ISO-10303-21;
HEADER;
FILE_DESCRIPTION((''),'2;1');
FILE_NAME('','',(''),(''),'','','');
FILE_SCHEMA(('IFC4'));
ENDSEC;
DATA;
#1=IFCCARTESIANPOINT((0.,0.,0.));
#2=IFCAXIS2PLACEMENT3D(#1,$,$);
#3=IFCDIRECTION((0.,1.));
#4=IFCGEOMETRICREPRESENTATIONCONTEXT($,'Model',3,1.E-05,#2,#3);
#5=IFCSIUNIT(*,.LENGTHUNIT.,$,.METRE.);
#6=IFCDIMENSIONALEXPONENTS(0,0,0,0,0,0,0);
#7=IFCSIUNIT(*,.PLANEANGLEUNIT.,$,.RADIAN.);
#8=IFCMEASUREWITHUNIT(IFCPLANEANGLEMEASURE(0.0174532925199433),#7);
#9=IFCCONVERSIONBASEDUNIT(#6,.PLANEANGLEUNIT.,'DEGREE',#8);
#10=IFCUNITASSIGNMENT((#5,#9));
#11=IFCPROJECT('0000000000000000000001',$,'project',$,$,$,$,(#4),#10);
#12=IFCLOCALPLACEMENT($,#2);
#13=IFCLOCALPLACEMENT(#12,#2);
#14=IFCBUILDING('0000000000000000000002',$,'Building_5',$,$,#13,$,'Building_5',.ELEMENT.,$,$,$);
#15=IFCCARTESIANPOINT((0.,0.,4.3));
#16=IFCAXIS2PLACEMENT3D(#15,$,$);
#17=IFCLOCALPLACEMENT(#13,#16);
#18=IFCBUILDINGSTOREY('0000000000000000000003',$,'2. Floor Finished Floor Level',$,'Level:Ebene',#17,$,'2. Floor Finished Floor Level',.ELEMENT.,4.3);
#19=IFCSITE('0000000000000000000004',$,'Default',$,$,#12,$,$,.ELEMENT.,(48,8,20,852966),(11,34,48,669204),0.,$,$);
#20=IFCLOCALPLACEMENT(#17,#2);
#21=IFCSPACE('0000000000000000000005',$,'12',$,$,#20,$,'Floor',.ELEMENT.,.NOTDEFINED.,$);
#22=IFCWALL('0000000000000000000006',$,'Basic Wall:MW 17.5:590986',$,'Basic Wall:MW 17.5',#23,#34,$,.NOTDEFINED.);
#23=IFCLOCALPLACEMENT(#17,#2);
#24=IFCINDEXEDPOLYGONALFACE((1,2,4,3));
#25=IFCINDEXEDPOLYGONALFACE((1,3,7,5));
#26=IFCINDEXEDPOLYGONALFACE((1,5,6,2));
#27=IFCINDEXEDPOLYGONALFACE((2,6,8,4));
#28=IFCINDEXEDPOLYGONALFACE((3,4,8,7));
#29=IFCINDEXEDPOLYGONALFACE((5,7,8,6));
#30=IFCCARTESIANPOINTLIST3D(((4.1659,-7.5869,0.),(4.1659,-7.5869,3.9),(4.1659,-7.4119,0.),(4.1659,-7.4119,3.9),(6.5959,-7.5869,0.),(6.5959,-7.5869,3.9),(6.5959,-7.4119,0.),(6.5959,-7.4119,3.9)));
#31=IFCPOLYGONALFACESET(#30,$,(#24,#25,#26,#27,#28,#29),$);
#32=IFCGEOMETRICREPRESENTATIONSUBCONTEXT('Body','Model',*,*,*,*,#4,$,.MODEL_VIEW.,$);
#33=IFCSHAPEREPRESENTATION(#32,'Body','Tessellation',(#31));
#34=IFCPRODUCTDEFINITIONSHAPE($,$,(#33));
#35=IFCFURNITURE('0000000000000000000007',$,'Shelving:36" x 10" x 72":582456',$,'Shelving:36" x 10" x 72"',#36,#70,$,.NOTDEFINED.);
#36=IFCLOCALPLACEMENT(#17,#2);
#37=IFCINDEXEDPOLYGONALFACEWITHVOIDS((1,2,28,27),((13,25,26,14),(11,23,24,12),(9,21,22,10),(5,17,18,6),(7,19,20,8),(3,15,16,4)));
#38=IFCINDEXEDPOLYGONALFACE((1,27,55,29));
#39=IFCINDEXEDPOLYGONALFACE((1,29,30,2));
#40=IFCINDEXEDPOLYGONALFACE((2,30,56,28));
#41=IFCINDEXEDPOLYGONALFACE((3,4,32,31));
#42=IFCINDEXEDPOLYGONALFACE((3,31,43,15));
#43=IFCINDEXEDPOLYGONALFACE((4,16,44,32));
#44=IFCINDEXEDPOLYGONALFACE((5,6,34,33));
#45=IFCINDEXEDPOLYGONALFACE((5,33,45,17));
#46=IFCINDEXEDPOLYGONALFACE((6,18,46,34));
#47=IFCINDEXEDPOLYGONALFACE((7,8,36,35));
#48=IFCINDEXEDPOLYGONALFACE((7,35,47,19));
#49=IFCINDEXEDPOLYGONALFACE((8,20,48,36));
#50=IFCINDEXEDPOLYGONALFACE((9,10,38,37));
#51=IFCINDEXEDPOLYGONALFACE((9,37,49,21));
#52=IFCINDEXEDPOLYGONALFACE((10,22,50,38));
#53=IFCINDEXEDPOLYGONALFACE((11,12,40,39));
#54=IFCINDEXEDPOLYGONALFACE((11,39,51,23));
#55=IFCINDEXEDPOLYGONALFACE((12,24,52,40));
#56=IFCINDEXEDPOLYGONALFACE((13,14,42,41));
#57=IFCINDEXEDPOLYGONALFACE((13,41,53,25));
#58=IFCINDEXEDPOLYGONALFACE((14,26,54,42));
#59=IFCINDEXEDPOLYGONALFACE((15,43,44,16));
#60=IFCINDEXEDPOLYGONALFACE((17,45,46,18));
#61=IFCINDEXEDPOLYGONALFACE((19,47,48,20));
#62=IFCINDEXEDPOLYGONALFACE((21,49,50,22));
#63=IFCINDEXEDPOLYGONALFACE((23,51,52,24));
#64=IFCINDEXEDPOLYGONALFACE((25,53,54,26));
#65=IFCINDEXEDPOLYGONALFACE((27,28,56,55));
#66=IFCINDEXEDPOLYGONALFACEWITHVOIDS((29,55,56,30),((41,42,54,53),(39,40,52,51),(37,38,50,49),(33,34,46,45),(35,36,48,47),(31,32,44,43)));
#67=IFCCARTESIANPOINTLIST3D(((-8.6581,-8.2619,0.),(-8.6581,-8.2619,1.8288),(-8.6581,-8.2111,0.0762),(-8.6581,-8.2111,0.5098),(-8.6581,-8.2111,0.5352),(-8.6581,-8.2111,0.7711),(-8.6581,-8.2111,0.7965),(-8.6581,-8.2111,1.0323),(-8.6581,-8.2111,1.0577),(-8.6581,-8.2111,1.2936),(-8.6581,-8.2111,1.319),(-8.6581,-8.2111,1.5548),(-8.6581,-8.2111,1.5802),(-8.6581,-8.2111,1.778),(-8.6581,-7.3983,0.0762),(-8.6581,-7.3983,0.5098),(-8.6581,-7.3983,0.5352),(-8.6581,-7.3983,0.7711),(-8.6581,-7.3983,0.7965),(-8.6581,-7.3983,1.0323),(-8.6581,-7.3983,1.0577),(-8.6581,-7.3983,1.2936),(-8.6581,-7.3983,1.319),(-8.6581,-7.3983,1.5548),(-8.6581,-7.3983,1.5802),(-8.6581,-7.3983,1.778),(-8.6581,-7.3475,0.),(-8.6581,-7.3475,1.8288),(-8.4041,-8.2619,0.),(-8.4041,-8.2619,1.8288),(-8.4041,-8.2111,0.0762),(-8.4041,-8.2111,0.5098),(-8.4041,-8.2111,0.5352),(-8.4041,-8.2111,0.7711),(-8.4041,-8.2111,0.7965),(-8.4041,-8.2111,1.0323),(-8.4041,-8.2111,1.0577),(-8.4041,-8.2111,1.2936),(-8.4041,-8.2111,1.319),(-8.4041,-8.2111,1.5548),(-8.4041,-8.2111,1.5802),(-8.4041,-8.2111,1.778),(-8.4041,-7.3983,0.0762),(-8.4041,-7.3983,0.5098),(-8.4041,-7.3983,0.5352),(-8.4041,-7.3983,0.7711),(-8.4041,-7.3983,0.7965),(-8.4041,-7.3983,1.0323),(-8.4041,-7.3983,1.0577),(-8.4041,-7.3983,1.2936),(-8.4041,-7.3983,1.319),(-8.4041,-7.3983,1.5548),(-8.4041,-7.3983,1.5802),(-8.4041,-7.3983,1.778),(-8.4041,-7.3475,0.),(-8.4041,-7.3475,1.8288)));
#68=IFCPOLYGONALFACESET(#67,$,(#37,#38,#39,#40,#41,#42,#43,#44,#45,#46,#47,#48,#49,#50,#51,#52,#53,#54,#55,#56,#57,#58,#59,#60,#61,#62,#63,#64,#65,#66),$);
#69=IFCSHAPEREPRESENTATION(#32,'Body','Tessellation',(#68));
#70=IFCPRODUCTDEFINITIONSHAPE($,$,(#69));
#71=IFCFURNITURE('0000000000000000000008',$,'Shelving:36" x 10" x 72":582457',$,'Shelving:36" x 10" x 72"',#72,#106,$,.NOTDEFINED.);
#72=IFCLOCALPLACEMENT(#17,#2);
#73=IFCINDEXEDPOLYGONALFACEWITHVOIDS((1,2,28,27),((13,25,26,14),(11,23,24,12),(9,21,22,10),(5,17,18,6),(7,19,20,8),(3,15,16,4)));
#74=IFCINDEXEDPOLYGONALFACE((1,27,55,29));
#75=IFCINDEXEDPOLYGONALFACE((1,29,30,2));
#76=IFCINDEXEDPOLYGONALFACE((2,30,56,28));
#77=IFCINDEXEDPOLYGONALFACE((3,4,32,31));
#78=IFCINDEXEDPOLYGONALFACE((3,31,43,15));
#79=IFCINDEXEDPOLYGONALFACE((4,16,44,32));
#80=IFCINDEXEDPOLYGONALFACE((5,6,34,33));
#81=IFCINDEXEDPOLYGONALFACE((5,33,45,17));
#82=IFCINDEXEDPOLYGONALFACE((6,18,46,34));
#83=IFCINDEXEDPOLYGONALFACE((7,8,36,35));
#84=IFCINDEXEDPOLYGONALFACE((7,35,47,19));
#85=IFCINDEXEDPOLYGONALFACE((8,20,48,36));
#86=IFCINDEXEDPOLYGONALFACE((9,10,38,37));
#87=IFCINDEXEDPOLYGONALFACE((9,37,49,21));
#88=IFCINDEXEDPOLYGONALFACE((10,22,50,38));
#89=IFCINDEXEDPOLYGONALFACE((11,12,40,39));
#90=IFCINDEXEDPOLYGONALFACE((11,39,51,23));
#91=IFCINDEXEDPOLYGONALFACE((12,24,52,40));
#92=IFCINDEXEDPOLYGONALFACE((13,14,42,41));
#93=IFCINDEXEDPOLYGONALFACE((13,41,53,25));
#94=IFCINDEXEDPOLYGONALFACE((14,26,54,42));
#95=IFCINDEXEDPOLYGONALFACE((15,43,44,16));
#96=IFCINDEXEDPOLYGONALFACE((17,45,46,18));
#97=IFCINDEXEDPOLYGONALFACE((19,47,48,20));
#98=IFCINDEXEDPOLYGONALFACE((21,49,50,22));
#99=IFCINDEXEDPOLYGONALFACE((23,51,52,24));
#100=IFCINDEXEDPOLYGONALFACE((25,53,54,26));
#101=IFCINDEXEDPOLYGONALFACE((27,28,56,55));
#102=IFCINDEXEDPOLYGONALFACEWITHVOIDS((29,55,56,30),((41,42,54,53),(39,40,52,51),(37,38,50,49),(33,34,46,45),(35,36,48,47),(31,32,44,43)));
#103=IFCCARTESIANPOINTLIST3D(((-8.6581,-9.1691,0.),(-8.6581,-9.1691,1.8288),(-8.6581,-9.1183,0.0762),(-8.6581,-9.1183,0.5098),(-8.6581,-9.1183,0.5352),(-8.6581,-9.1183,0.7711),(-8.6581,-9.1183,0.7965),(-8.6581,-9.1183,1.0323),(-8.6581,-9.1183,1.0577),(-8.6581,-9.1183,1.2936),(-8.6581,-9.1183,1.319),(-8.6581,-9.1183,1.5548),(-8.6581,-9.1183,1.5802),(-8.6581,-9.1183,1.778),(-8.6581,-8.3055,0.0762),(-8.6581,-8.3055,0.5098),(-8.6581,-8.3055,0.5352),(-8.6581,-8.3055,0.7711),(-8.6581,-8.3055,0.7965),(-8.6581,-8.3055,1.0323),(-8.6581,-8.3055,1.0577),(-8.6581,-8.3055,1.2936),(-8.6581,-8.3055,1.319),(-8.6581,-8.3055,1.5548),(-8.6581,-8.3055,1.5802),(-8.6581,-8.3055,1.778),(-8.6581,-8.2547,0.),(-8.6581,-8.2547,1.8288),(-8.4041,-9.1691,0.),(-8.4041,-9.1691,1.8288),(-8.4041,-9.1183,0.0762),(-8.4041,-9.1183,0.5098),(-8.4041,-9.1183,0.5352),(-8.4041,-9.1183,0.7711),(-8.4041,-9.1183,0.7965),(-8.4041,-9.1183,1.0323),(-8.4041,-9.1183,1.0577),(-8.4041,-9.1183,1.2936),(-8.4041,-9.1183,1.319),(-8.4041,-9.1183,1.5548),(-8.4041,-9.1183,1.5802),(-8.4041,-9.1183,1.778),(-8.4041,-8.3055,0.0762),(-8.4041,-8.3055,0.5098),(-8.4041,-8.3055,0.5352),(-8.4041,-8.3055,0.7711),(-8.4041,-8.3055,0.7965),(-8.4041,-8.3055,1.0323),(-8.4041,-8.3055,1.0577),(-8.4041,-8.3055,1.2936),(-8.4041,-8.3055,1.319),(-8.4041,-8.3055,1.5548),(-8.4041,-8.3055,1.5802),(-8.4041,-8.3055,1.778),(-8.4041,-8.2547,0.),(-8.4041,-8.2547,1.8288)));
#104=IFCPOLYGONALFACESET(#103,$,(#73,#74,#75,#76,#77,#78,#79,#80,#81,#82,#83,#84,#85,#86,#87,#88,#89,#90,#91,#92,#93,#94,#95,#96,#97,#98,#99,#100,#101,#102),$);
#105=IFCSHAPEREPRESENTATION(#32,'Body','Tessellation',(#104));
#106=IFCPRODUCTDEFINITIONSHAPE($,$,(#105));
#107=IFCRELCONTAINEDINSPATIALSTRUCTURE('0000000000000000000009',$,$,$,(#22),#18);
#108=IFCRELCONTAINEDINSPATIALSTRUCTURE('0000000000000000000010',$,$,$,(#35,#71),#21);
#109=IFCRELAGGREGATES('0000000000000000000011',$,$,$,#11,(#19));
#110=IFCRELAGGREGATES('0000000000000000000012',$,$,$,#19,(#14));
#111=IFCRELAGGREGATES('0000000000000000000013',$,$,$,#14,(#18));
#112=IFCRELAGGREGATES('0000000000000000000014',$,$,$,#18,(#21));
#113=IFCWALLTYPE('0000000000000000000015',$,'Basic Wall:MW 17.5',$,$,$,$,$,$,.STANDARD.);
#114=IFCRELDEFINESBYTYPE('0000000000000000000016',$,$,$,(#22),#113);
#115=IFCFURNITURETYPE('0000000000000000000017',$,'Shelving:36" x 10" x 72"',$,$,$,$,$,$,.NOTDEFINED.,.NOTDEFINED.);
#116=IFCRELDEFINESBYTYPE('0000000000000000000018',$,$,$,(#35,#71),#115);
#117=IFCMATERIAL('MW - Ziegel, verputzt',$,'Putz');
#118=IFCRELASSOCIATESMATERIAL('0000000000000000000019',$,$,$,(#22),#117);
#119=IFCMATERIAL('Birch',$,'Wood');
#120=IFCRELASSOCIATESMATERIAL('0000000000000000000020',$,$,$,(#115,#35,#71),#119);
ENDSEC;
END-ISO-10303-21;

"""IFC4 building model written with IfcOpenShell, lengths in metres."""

from ifc_helpers import new_model, entity, si_unit, converted_unit, direction, frame, origin, place, context, subcontext, project, spatial, indexed_curve, outline, extrude, source, transform, mapped, material, type_object, type_shapes, element, save


model = new_model("IFC4")

# Units and contexts
model_context = context("Model", 3, precision=1e-05, world=origin(), true_north=direction((0.0, 1.0)))
body_context = subcontext(model_context, "Body", "Model", "MODEL_VIEW")
ifc_project = project(units=[si_unit("LENGTHUNIT", "METRE"), converted_unit("PLANEANGLEUNIT", "DEGREE", entity("IfcPlaneAngleMeasure", 0.0174532925199433), si_unit("PLANEANGLEUNIT", "RADIAN"), dimensions=[0, 0, 0, 0, 0, 0, 0])], contexts=[model_context])

# Site, building, storey
site_placement = place(None, origin())
site = spatial("IfcSite", under=ifc_project, at=site_placement, Name="Default", CompositionType="ELEMENT", RefLatitude=(48, 8, 20, 852966), RefLongitude=(11, 34, 48, 669204), RefElevation=0.0)
building_placement = place(site_placement, origin())
building = spatial("IfcBuilding", under=site, at=building_placement, Name="Building_5", LongName="Building_5", CompositionType="ELEMENT")
storey_placement = place(building_placement, frame((0.0, 0.0, 4.3)))
storey = spatial("IfcBuildingStorey", under=building, at=storey_placement, Name="2. Floor Finished Floor Level", ObjectType="Level:Ebene", LongName="2. Floor Finished Floor Level", CompositionType="ELEMENT", Elevation=4.3)

# Wall
ifc_material_1 = material(Name="MW - Ziegel, verputzt", Category="Putz")
wall_type_1 = type_object("IfcWallType", Name="Basic Wall:MW 17.5", PredefinedType="STANDARD")
wall_1_placement = place(storey_placement, frame((4.1659, -7.4994, 0.0)))
element("IfcWall", 1, at=wall_1_placement, inside=storey, type_object=wall_type_1, material=ifc_material_1, Name="Basic Wall:MW 17.5:590986", ObjectType="Basic Wall:MW 17.5", PredefinedType="NOTDEFINED", context=body_context, shape_type="SweptSolid", body=[
    extrude(outline(indexed_curve([(2.43, 0.0875), (0.0, 0.0875), (0.0, -0.0875), (2.43, -0.0875), (2.43, 0.0875)], self_intersect=False)), origin(), (0.0, 0.0, 1.0), 3.9),
])

# Shared definitions
space_placement = place(storey_placement, origin())
space = spatial("IfcSpace", under=storey, at=space_placement, Name="12", LongName="Floor", CompositionType="ELEMENT", PredefinedType="NOTDEFINED")

# Furniture
ifc_material_2 = material(Name="Birch", Category="Wood")
furniture_type = type_object("IfcFurnitureType", Name="Shelving:36\" x 10\" x 72\"", AssemblyPlace="NOTDEFINED", PredefinedType="NOTDEFINED", material=ifc_material_2)
shared_shape = source(origin(), body_context, "Body", "SweptSolid", [
    extrude(outline(indexed_curve([(-0.4572, -0.9144), (0.4572, -0.9144), (0.4572, 0.9144), (-0.4572, 0.9144), (-0.4572, -0.9144)], self_intersect=False), holes=[indexed_curve([(-0.4064, 0.8636), (0.4064, 0.8636), (0.4064, 0.6658), (-0.4064, 0.6658), (-0.4064, 0.8636)], self_intersect=False), indexed_curve([(-0.4064, -0.8382), (-0.4064, -0.4046), (0.4064, -0.4046), (0.4064, -0.8382), (-0.4064, -0.8382)], self_intersect=False), indexed_curve([(0.4064, 0.1433), (-0.4064, 0.1433), (-0.4064, 0.3792), (0.4064, 0.3792), (0.4064, 0.1433)], self_intersect=False), indexed_curve([(-0.4064, 0.6404), (0.4064, 0.6404), (0.4064, 0.4046), (-0.4064, 0.4046), (-0.4064, 0.6404)], self_intersect=False), indexed_curve([(-0.4064, 0.1179), (0.4064, 0.1179), (0.4064, -0.1179), (-0.4064, -0.1179), (-0.4064, 0.1179)], self_intersect=False), indexed_curve([(-0.4064, -0.1433), (0.4064, -0.1433), (0.4064, -0.3792), (-0.4064, -0.3792), (-0.4064, -0.1433)], self_intersect=False)]), frame((0.0, 0.1778, 0.9144), z_axis=(0.0, 1.0, 0.0), x_axis=(-1.0, 0.0, 0.0)), (0.0, 0.0, 1.0), 0.254),
])
type_shapes(furniture_type, [shared_shape])
for number, where, z_axis, x_axis, name in (
    (2, (-8.2263, -7.8047, 0.0), (0.0, 0.0, 1.0), (0.0, 1.0, 0.0), "Shelving:36\" x 10\" x 72\":582456"),
    (3, (-8.2263, -8.7119, 0.0), (0.0, 0.0, 1.0), (0.0, 1.0, 0.0), "Shelving:36\" x 10\" x 72\":582457"),
):
    element("IfcFurniture", number, at=place(space_placement, frame(where, z_axis=z_axis, x_axis=x_axis)), inside=space, type_object=furniture_type, material=ifc_material_2, Name=name, ObjectType="Shelving:36\" x 10\" x 72\"", PredefinedType="NOTDEFINED", context=body_context, shape_type="MappedRepresentation", body=[
        mapped(shared_shape, transform((0.0, 0.0, 0.0), scale=1.0)),
    ])

save(model, "model.ifc")
